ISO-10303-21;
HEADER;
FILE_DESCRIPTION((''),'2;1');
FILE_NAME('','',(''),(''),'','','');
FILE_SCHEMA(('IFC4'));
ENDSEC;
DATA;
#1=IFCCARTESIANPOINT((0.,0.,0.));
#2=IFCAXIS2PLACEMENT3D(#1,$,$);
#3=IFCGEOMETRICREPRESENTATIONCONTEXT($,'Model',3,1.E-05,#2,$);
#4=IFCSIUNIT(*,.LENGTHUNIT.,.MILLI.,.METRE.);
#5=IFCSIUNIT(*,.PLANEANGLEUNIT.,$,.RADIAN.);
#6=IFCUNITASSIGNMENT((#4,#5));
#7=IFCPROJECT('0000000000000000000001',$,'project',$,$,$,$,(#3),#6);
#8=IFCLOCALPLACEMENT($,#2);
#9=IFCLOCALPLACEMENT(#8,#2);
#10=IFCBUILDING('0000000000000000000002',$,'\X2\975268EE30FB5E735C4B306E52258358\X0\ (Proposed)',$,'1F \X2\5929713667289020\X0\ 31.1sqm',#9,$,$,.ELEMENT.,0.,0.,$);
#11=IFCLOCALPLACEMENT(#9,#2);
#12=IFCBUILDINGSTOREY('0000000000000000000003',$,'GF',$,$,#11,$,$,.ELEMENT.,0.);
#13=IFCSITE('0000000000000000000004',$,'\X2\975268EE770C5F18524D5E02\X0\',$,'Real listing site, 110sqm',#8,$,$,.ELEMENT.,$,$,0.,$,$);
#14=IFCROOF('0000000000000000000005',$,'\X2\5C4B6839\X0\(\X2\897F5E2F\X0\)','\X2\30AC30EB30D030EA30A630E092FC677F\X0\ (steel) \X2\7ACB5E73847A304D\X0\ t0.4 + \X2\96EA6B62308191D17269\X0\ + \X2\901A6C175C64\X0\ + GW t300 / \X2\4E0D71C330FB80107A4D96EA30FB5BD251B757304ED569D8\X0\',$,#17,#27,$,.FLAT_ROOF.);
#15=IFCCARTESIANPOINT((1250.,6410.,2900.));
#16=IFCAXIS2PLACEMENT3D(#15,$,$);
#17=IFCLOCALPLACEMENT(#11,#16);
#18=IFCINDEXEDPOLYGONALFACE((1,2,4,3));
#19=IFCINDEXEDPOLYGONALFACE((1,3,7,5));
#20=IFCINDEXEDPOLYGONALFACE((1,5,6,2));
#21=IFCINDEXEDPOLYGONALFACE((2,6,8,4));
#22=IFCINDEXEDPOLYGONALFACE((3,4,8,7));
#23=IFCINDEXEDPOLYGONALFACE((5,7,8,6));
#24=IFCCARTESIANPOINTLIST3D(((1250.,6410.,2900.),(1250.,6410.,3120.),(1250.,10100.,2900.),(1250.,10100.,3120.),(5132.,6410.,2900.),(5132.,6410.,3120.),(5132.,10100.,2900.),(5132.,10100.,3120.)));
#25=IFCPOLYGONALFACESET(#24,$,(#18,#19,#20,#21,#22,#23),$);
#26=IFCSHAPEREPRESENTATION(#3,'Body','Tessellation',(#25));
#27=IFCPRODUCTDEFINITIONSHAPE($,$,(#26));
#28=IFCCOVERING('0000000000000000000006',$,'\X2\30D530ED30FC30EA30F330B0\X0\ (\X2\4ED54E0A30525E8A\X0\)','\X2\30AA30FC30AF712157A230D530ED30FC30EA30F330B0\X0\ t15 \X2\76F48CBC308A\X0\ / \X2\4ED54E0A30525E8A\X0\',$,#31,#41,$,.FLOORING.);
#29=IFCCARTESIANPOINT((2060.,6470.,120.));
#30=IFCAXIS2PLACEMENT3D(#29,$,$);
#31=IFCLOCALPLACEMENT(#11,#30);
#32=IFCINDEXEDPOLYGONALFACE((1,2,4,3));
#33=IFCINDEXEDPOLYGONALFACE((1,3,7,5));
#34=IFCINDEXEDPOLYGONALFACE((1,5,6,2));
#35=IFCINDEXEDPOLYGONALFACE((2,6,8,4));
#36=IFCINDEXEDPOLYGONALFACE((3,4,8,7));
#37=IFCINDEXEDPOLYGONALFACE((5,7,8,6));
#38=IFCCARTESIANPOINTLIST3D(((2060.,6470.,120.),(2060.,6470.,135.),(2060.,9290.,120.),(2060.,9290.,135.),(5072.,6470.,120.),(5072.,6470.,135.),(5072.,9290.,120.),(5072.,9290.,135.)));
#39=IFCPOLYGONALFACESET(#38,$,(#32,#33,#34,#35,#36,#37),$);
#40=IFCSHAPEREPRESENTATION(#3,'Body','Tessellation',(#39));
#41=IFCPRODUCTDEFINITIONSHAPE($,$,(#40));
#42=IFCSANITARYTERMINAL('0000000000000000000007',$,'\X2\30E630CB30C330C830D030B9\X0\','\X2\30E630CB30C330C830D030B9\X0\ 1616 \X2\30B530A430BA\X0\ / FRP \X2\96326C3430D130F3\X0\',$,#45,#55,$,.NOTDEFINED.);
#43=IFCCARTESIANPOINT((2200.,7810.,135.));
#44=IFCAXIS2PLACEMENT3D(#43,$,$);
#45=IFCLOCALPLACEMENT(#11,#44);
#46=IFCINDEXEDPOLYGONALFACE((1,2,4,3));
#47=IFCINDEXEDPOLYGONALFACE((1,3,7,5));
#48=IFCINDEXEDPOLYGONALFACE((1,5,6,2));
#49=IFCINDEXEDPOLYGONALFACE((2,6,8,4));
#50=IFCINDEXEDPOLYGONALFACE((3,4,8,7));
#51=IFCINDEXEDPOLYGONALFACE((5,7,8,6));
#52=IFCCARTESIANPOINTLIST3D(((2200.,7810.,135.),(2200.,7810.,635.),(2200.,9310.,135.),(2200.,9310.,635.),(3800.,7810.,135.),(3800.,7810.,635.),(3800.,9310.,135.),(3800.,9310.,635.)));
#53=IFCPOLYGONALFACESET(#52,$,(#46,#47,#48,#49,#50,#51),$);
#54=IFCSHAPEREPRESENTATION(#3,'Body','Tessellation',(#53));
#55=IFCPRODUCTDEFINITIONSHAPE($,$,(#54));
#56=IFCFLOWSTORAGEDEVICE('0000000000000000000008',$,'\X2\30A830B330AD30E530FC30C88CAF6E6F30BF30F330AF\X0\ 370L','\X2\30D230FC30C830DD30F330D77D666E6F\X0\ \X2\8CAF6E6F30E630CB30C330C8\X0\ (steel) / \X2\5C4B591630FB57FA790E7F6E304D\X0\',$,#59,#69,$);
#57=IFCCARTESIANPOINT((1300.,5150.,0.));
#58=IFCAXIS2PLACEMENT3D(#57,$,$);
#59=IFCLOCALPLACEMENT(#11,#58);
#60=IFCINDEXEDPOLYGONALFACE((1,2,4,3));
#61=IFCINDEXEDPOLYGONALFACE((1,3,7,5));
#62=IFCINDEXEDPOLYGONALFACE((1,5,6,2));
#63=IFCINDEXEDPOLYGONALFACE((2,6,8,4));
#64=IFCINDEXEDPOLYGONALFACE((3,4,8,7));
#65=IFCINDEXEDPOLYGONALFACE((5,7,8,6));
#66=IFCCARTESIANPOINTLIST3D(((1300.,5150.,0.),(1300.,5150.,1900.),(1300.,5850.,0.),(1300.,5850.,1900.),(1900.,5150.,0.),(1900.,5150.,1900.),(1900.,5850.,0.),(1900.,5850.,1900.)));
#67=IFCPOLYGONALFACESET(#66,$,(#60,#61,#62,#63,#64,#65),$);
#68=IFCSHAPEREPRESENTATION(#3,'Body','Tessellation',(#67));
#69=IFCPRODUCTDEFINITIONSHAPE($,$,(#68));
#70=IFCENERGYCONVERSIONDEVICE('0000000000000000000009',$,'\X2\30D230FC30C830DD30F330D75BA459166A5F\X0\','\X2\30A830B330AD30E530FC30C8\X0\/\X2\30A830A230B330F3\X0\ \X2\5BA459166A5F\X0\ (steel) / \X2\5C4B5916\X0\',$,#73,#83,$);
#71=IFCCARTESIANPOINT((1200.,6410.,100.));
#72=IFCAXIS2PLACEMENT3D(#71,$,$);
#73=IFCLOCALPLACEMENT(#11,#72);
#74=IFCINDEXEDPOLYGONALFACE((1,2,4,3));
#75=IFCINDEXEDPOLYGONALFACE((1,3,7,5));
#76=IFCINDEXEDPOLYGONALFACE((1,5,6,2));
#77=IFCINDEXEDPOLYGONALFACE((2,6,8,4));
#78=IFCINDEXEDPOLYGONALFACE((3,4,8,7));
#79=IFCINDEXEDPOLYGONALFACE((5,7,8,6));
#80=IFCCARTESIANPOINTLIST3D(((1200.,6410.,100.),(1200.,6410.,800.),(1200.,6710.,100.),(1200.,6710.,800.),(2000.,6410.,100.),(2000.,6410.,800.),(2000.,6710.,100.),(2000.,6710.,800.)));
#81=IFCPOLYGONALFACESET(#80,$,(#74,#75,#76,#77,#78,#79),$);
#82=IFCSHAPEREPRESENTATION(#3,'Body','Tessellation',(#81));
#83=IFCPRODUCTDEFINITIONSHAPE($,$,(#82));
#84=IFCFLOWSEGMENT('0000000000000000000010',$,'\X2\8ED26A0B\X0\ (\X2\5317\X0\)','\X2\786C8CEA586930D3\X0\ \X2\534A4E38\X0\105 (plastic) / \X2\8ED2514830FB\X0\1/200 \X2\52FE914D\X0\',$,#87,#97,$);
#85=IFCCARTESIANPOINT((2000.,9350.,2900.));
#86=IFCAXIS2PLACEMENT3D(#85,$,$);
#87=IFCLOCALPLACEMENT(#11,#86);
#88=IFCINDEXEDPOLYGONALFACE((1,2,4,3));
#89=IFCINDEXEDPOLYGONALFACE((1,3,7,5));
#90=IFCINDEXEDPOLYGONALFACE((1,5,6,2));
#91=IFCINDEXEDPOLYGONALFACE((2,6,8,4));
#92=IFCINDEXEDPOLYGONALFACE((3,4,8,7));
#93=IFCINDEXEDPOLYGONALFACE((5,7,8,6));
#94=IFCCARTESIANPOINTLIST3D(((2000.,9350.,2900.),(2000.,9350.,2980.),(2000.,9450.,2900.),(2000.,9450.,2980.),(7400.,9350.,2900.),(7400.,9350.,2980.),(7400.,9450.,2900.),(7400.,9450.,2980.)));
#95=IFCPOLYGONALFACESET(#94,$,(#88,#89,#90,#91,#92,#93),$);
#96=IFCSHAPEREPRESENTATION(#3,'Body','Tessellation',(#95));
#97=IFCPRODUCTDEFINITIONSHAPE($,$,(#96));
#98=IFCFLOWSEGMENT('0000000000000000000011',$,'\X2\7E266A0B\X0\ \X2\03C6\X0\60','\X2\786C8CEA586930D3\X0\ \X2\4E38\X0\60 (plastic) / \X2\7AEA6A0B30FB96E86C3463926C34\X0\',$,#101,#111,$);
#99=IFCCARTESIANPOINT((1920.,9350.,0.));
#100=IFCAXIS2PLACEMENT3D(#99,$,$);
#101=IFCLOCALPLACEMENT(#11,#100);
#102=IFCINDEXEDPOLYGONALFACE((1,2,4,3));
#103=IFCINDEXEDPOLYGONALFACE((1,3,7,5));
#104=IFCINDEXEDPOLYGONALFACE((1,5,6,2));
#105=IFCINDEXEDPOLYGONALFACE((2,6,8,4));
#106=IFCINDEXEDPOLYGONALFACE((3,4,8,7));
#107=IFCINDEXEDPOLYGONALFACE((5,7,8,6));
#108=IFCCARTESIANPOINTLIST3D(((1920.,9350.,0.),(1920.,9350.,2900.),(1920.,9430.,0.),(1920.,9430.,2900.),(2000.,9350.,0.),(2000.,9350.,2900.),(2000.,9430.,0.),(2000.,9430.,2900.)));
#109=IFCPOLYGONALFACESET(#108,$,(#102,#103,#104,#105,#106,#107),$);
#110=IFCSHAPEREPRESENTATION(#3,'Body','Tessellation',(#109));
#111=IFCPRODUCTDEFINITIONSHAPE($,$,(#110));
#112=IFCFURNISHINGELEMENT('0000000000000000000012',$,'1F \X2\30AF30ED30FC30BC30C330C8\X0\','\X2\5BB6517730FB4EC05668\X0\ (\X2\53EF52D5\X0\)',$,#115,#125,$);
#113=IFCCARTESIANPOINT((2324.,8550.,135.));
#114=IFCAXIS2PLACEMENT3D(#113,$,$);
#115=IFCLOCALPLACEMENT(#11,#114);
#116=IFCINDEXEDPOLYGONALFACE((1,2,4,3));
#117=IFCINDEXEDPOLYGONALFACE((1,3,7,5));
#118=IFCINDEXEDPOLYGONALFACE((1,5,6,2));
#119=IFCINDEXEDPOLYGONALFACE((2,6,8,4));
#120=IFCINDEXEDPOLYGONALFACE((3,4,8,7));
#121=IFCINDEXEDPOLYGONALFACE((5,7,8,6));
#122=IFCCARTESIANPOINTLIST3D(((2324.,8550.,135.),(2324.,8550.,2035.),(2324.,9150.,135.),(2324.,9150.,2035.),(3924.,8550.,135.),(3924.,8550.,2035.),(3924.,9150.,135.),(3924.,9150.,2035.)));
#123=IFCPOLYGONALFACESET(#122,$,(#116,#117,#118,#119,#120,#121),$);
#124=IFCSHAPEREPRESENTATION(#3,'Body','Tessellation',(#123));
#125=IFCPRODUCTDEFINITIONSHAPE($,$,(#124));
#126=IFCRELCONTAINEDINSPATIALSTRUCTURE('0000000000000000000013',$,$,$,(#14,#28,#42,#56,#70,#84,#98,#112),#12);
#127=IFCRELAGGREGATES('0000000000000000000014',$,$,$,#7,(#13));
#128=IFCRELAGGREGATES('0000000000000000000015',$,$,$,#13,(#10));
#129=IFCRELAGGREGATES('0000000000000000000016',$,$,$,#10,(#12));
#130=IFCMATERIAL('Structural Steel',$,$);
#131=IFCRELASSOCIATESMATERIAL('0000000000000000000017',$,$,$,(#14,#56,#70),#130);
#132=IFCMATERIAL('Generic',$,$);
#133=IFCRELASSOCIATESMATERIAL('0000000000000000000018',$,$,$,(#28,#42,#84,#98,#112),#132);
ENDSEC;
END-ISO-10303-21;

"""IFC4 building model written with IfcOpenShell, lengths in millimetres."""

from ifc_helpers import new_model, si_unit, frame, frame_2d, origin, place, context, project, spatial, rectangle, extrude, material, element, save


model = new_model("IFC4")

# Units and contexts
model_context = context("Model", 3, precision=1e-05, world=origin())
ifc_project = project(units=[si_unit("LENGTHUNIT", "METRE", prefix="MILLI"), si_unit("PLANEANGLEUNIT", "RADIAN")], contexts=[model_context])

# Site, building, storey
site_placement = place(None, origin())
site = spatial("IfcSite", under=ifc_project, at=site_placement, Name="青森県弘前市", ObjectType="Real listing site, 110sqm", CompositionType="ELEMENT", RefElevation=0.0)
building_placement = place(site_placement, origin())
building = spatial("IfcBuilding", under=site, at=building_placement, Name="青森・平屋の別荘 (Proposed)", ObjectType="1F 天然木造 31.1sqm", CompositionType="ELEMENT", ElevationOfRefHeight=0.0, ElevationOfTerrain=0.0)
storey_placement = place(building_placement, origin())
storey = spatial("IfcBuildingStorey", under=building, at=storey_placement, Name="GF", CompositionType="ELEMENT", Elevation=0.0)

# Roof
ifc_material_1 = material(Name="Structural Steel")
roof_placement = place(storey_placement, frame((1250.0, 6410.0, 2900.0)))
element("IfcRoof", 1, at=roof_placement, inside=storey, material=ifc_material_1, Name="屋根(西帯)", Description="ガルバリウム鋼板 (steel) 立平葺き t0.4 + 雪止め金物 + 通気層 + GW t300 / 不燃・耐積雪・寒冷地仕様", PredefinedType="FLAT_ROOF", context=model_context, shape_type="SweptSolid", body=[
    extrude(rectangle(XDim=3882.0, YDim=3690.0, at=frame_2d((1941.0, 1845.0))), frame((1250.0, 6410.0, 2900.0)), (0.0, 0.0, 1.0), 220.0),
])

# Covering
ifc_material_2 = material(Name="Generic")
covering_placement = place(storey_placement, frame((2060.0, 6470.0, 120.0)))
element("IfcCovering", 2, at=covering_placement, inside=storey, material=ifc_material_2, Name="フローリング (仕上げ床)", Description="オーク無垢フローリング t15 直貼り / 仕上げ床", PredefinedType="FLOORING", context=model_context, shape_type="SweptSolid", body=[
    extrude(rectangle(XDim=3012.0, YDim=2820.0, at=frame_2d((1506.0, 1410.0))), frame((2060.0, 6470.0, 120.0)), (0.0, 0.0, 1.0), 15.0),
])

# Sanitary terminal
sanitary_terminal_placement = place(storey_placement, frame((2200.0, 7810.0, 135.0)))
element("IfcSanitaryTerminal", 3, at=sanitary_terminal_placement, inside=storey, material=ifc_material_2, Name="ユニットバス", Description="ユニットバス 1616 サイズ / FRP 防水パン", PredefinedType="NOTDEFINED", context=model_context, shape_type="SweptSolid", body=[
    extrude(rectangle(XDim=1600.0, YDim=1500.0, at=frame_2d((800.0, 750.0))), frame((2200.0, 7810.0, 135.0)), (0.0, 0.0, 1.0), 500.0),
])

# Flow storage device
flow_storage_device_placement = place(storey_placement, frame((1300.0, 5150.0, 0.0)))
element("IfcFlowStorageDevice", 4, at=flow_storage_device_placement, inside=storey, material=ifc_material_1, Name="エコキュート貯湯タンク 370L", Description="ヒートポンプ給湯 貯湯ユニット (steel) / 屋外・基礎置き", context=model_context, shape_type="SweptSolid", body=[
    extrude(rectangle(XDim=600.0, YDim=700.0, at=frame_2d((300.0, 350.0))), frame((1300.0, 5150.0, 0.0)), (0.0, 0.0, 1.0), 1900.0),
])

# Energy conversion device
energy_conversion_device_placement = place(storey_placement, frame((1200.0, 6410.0, 100.0)))
element("IfcEnergyConversionDevice", 5, at=energy_conversion_device_placement, inside=storey, material=ifc_material_1, Name="ヒートポンプ室外機", Description="エコキュート/エアコン 室外機 (steel) / 屋外", context=model_context, shape_type="SweptSolid", body=[
    extrude(rectangle(XDim=800.0, YDim=300.0, at=frame_2d((400.0, 150.0))), frame((1200.0, 6410.0, 100.0)), (0.0, 0.0, 1.0), 700.0),
])

# Flow segments
flow_segment_1_placement = place(storey_placement, frame((2000.0, 9350.0, 2900.0)))
element("IfcFlowSegment", 6, at=flow_segment_1_placement, inside=storey, material=ifc_material_2, Name="軒樋 (北)", Description="硬質塩ビ 半丸105 (plastic) / 軒先・1/200 勾配", context=model_context, shape_type="SweptSolid", body=[
    extrude(rectangle(XDim=5400.0, YDim=100.0, at=frame_2d((2700.0, 50.0))), frame((2000.0, 9350.0, 2900.0)), (0.0, 0.0, 1.0), 80.0),
])
flow_segment_2_placement = place(storey_placement, frame((1920.0, 9350.0, 0.0)))
element("IfcFlowSegment", 7, at=flow_segment_2_placement, inside=storey, material=ifc_material_2, Name="縦樋 φ60", Description="硬質塩ビ 丸60 (plastic) / 竪樋・雨水排水", context=model_context, shape_type="SweptSolid", body=[
    extrude(rectangle(XDim=80.0, YDim=80.0, at=frame_2d((40.0, 40.0))), frame((1920.0, 9350.0, 0.0)), (0.0, 0.0, 1.0), 2900.0),
])

# Furnishing element
furnishing_placement = place(storey_placement, frame((2324.0, 8550.0, 135.0)))
element("IfcFurnishingElement", 8, at=furnishing_placement, inside=storey, material=ifc_material_2, Name="1F クローゼット", Description="家具・什器 (可動)", context=model_context, shape_type="SweptSolid", body=[
    extrude(rectangle(XDim=1600.0, YDim=600.0, at=frame_2d((800.0, 300.0))), frame((2324.0, 8550.0, 135.0)), (0.0, 0.0, 1.0), 1900.0),
])

save(model, "model.ifc")
